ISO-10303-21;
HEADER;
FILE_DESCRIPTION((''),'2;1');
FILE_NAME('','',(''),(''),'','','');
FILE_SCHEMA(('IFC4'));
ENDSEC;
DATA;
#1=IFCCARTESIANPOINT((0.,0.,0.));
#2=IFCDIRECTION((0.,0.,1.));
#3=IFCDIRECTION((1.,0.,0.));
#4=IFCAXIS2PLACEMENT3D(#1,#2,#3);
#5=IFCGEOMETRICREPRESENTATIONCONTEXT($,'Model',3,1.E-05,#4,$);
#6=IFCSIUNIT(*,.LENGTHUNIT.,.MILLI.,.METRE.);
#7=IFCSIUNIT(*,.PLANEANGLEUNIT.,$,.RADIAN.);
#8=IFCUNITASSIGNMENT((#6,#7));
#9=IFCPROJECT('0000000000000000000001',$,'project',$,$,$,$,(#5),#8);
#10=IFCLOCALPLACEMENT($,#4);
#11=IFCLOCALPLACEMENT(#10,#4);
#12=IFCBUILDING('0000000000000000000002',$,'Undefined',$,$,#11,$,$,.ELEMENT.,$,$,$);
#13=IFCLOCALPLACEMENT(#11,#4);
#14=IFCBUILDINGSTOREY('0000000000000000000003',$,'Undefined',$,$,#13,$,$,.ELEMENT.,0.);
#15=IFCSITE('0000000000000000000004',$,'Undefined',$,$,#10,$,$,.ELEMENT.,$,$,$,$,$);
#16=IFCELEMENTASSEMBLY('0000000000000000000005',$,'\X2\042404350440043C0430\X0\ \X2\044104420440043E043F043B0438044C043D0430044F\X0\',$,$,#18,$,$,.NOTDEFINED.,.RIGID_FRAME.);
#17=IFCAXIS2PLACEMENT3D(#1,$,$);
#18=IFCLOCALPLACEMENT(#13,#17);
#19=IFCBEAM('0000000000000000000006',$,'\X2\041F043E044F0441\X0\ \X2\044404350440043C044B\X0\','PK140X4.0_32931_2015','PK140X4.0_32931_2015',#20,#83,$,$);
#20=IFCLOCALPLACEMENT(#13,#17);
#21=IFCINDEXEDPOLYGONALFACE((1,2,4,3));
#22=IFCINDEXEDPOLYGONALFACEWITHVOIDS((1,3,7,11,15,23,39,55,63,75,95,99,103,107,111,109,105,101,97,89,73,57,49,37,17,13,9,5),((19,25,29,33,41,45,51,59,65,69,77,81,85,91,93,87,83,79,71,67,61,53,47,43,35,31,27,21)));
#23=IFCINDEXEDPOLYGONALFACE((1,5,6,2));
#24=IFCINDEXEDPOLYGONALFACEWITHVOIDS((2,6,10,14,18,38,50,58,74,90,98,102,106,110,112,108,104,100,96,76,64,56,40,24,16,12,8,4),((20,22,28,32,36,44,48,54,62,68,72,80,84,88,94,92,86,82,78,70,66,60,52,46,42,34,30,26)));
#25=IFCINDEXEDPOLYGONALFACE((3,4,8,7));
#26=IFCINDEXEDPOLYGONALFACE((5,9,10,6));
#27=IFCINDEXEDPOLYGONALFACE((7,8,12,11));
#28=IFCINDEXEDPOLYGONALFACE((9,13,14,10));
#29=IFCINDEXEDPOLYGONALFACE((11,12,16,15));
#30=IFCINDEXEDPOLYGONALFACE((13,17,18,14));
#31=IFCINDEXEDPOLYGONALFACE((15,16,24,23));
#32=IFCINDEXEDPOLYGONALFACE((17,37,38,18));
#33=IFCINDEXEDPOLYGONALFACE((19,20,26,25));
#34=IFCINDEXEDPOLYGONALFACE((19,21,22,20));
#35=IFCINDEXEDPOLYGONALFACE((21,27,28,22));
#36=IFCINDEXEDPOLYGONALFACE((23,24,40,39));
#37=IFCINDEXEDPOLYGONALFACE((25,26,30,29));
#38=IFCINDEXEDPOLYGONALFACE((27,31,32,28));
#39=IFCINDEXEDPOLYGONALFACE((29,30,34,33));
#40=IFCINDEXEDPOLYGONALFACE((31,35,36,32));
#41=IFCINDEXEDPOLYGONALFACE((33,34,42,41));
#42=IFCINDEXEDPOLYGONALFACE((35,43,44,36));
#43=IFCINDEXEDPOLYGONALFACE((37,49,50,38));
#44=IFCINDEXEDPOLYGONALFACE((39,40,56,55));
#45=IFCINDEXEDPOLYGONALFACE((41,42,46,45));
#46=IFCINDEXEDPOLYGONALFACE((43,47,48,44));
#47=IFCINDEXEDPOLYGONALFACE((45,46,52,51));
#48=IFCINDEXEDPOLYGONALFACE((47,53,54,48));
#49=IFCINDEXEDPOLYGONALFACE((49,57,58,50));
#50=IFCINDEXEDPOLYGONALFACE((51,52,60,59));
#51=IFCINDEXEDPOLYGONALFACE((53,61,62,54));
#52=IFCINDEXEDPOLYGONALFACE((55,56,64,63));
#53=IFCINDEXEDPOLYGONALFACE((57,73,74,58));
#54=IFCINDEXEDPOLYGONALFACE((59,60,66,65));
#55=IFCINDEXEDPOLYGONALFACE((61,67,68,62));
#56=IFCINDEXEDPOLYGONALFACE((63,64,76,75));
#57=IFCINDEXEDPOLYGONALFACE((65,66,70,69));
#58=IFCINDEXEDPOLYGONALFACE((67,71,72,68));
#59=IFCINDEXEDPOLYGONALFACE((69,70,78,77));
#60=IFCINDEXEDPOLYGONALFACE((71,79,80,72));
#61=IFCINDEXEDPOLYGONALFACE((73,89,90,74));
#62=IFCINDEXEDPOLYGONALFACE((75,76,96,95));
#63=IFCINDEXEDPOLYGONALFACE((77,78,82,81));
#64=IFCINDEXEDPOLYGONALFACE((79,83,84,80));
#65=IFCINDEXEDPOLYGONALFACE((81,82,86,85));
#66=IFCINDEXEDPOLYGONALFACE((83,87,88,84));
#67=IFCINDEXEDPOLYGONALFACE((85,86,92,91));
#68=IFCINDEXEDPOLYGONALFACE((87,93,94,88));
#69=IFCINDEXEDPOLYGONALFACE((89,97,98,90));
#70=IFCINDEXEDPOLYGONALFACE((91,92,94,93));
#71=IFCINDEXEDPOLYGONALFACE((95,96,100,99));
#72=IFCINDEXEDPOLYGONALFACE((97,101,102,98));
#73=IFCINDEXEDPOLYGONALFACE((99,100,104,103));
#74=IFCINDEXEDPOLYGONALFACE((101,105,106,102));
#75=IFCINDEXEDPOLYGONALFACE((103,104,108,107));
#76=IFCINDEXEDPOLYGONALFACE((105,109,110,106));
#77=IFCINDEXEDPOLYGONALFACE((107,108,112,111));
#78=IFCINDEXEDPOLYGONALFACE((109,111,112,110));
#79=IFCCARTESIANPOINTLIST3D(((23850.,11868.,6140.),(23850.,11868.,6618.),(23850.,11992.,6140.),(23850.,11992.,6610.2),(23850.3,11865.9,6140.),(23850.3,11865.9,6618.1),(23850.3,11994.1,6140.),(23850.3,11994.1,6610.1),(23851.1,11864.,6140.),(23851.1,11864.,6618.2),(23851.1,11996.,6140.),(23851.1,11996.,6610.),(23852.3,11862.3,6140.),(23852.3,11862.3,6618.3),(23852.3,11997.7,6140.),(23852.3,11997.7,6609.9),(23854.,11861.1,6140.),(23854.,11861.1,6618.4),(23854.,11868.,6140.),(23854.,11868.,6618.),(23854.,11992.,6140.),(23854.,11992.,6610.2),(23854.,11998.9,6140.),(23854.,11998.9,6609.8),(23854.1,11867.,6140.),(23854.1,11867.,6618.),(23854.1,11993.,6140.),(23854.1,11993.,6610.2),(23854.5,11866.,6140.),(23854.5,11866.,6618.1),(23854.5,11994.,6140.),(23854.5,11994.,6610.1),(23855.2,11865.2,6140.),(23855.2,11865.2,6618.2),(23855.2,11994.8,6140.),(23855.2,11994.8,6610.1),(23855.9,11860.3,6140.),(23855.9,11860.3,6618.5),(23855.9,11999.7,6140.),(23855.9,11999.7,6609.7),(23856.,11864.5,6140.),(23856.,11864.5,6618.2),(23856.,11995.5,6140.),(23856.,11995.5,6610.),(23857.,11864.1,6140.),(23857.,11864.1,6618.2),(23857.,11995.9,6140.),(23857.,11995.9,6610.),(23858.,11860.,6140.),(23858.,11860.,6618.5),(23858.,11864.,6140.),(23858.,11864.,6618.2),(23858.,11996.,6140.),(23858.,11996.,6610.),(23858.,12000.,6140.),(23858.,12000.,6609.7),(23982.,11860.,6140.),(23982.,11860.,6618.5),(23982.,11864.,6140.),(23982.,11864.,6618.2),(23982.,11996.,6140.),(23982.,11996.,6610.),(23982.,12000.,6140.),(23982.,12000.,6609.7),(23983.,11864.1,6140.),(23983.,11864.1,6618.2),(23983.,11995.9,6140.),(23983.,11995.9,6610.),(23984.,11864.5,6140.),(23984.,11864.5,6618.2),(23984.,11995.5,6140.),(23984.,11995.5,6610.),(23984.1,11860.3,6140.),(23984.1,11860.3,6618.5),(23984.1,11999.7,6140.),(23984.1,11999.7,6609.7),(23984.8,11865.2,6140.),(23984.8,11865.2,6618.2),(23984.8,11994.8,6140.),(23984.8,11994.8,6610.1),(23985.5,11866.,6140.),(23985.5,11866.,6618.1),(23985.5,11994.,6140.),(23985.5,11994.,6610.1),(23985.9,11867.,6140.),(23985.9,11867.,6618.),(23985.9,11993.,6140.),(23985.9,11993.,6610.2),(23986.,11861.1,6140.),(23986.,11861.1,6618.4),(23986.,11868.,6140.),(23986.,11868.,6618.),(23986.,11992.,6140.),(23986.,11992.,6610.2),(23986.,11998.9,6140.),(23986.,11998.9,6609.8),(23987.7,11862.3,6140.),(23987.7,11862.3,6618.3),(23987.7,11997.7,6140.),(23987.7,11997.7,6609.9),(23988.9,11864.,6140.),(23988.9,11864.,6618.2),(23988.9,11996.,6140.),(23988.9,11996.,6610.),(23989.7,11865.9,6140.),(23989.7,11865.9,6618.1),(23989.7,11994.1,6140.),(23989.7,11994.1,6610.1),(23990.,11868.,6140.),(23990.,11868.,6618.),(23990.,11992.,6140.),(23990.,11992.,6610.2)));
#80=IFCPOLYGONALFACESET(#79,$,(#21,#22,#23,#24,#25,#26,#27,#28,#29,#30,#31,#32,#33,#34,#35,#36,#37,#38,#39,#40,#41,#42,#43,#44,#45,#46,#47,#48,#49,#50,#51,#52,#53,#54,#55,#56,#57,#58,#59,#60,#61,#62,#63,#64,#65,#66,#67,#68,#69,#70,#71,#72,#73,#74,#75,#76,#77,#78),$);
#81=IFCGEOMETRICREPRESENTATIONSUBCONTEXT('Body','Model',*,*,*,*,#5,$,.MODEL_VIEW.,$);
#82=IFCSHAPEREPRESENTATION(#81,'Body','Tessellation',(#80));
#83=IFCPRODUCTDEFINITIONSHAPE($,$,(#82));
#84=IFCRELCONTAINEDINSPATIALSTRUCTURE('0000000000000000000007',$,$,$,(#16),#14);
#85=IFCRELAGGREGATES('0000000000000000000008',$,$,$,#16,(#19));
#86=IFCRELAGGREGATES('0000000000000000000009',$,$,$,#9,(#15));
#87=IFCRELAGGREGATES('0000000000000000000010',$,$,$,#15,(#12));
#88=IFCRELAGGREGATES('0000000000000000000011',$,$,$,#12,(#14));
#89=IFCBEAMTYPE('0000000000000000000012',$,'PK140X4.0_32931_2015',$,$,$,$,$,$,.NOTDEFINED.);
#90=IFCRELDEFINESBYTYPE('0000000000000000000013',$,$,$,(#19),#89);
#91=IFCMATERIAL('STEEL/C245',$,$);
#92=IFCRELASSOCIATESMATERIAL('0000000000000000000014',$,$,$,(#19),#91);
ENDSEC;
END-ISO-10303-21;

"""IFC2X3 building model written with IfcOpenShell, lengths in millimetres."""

from ifc_helpers import new_model, si_unit, frame, origin_with_axes, origin_2d_with_axis, place, context, subcontext, project, spatial, hollow_rectangle, extrude, clip, halfspace, material, type_object, element, aggregate, save


model = new_model("IFC2X3")

# Units and contexts
model_context = context("Model", 3, precision=1e-05, world=origin_with_axes())
body_context = subcontext(model_context, "Body", "Model", "MODEL_VIEW")
ifc_project = project(units=[si_unit("LENGTHUNIT", "METRE", prefix="MILLI"), si_unit("PLANEANGLEUNIT", "RADIAN")], contexts=[model_context])

# Site, building, storey
site_placement = place(None, origin_with_axes())
site = spatial("IfcSite", under=ifc_project, at=site_placement, Name="Undefined", CompositionType="ELEMENT")
building_placement = place(site_placement, origin_with_axes())
building = spatial("IfcBuilding", under=site, at=building_placement, Name="Undefined", CompositionType="ELEMENT")
storey_placement = place(building_placement, origin_with_axes())
storey = spatial("IfcBuildingStorey", under=building, at=storey_placement, Name="Undefined", CompositionType="ELEMENT", Elevation=0.0)

# Shared definitions
ifc_material = material(Name="STEEL/C245")

# Shared definitions
beam_type_1 = type_object("IfcBeamType", Name="PK140X4.0_32931_2015", PredefinedType="NOTDEFINED")

# Element assembly, beam
assembly_1_placement = place(storey_placement, origin_with_axes())
assembly_1 = element("IfcElementAssembly", 1, at=assembly_1_placement, inside=storey, Name="Ферма строплиьная", AssemblyPlace="NOTDEFINED", PredefinedType="RIGID_FRAME")
beam_1_placement = place(assembly_1_placement, frame((23920.0, 11930.0, 6609.7), z_axis=(1.0, 0.0, 0.0), x_axis=(0.0, 0.0, -1.0)))
beam_1 = element("IfcBeam", 2, at=beam_1_placement, type_object=beam_type_1, material=ifc_material, Name="Пояс фермы", Description="PK140X4.0_32931_2015", ObjectType="PK140X4.0_32931_2015", context=body_context, shape_type="Clipping", body=[
    clip(extrude(hollow_rectangle(XDim=140.0, YDim=140.0, WallThickness=4.0, InnerFilletRadius=4.0, OuterFilletRadius=8.0, at=origin_2d_with_axis()), frame((469.7, 0.0, 0.0), z_axis=(-1.0, 0.0, 0.0), x_axis=(0.0, -1.0, 0.0)), (0.0, 0.0, 1.0), 478.5), halfspace(frame((-14.9, -167.6, 0.0), z_axis=(-0.998053, 0.062378, 0.0), x_axis=(0.0, 0.0, 1.0)), False)),
])
aggregate(assembly_1, [beam_1])

save(model, "model.ifc")
